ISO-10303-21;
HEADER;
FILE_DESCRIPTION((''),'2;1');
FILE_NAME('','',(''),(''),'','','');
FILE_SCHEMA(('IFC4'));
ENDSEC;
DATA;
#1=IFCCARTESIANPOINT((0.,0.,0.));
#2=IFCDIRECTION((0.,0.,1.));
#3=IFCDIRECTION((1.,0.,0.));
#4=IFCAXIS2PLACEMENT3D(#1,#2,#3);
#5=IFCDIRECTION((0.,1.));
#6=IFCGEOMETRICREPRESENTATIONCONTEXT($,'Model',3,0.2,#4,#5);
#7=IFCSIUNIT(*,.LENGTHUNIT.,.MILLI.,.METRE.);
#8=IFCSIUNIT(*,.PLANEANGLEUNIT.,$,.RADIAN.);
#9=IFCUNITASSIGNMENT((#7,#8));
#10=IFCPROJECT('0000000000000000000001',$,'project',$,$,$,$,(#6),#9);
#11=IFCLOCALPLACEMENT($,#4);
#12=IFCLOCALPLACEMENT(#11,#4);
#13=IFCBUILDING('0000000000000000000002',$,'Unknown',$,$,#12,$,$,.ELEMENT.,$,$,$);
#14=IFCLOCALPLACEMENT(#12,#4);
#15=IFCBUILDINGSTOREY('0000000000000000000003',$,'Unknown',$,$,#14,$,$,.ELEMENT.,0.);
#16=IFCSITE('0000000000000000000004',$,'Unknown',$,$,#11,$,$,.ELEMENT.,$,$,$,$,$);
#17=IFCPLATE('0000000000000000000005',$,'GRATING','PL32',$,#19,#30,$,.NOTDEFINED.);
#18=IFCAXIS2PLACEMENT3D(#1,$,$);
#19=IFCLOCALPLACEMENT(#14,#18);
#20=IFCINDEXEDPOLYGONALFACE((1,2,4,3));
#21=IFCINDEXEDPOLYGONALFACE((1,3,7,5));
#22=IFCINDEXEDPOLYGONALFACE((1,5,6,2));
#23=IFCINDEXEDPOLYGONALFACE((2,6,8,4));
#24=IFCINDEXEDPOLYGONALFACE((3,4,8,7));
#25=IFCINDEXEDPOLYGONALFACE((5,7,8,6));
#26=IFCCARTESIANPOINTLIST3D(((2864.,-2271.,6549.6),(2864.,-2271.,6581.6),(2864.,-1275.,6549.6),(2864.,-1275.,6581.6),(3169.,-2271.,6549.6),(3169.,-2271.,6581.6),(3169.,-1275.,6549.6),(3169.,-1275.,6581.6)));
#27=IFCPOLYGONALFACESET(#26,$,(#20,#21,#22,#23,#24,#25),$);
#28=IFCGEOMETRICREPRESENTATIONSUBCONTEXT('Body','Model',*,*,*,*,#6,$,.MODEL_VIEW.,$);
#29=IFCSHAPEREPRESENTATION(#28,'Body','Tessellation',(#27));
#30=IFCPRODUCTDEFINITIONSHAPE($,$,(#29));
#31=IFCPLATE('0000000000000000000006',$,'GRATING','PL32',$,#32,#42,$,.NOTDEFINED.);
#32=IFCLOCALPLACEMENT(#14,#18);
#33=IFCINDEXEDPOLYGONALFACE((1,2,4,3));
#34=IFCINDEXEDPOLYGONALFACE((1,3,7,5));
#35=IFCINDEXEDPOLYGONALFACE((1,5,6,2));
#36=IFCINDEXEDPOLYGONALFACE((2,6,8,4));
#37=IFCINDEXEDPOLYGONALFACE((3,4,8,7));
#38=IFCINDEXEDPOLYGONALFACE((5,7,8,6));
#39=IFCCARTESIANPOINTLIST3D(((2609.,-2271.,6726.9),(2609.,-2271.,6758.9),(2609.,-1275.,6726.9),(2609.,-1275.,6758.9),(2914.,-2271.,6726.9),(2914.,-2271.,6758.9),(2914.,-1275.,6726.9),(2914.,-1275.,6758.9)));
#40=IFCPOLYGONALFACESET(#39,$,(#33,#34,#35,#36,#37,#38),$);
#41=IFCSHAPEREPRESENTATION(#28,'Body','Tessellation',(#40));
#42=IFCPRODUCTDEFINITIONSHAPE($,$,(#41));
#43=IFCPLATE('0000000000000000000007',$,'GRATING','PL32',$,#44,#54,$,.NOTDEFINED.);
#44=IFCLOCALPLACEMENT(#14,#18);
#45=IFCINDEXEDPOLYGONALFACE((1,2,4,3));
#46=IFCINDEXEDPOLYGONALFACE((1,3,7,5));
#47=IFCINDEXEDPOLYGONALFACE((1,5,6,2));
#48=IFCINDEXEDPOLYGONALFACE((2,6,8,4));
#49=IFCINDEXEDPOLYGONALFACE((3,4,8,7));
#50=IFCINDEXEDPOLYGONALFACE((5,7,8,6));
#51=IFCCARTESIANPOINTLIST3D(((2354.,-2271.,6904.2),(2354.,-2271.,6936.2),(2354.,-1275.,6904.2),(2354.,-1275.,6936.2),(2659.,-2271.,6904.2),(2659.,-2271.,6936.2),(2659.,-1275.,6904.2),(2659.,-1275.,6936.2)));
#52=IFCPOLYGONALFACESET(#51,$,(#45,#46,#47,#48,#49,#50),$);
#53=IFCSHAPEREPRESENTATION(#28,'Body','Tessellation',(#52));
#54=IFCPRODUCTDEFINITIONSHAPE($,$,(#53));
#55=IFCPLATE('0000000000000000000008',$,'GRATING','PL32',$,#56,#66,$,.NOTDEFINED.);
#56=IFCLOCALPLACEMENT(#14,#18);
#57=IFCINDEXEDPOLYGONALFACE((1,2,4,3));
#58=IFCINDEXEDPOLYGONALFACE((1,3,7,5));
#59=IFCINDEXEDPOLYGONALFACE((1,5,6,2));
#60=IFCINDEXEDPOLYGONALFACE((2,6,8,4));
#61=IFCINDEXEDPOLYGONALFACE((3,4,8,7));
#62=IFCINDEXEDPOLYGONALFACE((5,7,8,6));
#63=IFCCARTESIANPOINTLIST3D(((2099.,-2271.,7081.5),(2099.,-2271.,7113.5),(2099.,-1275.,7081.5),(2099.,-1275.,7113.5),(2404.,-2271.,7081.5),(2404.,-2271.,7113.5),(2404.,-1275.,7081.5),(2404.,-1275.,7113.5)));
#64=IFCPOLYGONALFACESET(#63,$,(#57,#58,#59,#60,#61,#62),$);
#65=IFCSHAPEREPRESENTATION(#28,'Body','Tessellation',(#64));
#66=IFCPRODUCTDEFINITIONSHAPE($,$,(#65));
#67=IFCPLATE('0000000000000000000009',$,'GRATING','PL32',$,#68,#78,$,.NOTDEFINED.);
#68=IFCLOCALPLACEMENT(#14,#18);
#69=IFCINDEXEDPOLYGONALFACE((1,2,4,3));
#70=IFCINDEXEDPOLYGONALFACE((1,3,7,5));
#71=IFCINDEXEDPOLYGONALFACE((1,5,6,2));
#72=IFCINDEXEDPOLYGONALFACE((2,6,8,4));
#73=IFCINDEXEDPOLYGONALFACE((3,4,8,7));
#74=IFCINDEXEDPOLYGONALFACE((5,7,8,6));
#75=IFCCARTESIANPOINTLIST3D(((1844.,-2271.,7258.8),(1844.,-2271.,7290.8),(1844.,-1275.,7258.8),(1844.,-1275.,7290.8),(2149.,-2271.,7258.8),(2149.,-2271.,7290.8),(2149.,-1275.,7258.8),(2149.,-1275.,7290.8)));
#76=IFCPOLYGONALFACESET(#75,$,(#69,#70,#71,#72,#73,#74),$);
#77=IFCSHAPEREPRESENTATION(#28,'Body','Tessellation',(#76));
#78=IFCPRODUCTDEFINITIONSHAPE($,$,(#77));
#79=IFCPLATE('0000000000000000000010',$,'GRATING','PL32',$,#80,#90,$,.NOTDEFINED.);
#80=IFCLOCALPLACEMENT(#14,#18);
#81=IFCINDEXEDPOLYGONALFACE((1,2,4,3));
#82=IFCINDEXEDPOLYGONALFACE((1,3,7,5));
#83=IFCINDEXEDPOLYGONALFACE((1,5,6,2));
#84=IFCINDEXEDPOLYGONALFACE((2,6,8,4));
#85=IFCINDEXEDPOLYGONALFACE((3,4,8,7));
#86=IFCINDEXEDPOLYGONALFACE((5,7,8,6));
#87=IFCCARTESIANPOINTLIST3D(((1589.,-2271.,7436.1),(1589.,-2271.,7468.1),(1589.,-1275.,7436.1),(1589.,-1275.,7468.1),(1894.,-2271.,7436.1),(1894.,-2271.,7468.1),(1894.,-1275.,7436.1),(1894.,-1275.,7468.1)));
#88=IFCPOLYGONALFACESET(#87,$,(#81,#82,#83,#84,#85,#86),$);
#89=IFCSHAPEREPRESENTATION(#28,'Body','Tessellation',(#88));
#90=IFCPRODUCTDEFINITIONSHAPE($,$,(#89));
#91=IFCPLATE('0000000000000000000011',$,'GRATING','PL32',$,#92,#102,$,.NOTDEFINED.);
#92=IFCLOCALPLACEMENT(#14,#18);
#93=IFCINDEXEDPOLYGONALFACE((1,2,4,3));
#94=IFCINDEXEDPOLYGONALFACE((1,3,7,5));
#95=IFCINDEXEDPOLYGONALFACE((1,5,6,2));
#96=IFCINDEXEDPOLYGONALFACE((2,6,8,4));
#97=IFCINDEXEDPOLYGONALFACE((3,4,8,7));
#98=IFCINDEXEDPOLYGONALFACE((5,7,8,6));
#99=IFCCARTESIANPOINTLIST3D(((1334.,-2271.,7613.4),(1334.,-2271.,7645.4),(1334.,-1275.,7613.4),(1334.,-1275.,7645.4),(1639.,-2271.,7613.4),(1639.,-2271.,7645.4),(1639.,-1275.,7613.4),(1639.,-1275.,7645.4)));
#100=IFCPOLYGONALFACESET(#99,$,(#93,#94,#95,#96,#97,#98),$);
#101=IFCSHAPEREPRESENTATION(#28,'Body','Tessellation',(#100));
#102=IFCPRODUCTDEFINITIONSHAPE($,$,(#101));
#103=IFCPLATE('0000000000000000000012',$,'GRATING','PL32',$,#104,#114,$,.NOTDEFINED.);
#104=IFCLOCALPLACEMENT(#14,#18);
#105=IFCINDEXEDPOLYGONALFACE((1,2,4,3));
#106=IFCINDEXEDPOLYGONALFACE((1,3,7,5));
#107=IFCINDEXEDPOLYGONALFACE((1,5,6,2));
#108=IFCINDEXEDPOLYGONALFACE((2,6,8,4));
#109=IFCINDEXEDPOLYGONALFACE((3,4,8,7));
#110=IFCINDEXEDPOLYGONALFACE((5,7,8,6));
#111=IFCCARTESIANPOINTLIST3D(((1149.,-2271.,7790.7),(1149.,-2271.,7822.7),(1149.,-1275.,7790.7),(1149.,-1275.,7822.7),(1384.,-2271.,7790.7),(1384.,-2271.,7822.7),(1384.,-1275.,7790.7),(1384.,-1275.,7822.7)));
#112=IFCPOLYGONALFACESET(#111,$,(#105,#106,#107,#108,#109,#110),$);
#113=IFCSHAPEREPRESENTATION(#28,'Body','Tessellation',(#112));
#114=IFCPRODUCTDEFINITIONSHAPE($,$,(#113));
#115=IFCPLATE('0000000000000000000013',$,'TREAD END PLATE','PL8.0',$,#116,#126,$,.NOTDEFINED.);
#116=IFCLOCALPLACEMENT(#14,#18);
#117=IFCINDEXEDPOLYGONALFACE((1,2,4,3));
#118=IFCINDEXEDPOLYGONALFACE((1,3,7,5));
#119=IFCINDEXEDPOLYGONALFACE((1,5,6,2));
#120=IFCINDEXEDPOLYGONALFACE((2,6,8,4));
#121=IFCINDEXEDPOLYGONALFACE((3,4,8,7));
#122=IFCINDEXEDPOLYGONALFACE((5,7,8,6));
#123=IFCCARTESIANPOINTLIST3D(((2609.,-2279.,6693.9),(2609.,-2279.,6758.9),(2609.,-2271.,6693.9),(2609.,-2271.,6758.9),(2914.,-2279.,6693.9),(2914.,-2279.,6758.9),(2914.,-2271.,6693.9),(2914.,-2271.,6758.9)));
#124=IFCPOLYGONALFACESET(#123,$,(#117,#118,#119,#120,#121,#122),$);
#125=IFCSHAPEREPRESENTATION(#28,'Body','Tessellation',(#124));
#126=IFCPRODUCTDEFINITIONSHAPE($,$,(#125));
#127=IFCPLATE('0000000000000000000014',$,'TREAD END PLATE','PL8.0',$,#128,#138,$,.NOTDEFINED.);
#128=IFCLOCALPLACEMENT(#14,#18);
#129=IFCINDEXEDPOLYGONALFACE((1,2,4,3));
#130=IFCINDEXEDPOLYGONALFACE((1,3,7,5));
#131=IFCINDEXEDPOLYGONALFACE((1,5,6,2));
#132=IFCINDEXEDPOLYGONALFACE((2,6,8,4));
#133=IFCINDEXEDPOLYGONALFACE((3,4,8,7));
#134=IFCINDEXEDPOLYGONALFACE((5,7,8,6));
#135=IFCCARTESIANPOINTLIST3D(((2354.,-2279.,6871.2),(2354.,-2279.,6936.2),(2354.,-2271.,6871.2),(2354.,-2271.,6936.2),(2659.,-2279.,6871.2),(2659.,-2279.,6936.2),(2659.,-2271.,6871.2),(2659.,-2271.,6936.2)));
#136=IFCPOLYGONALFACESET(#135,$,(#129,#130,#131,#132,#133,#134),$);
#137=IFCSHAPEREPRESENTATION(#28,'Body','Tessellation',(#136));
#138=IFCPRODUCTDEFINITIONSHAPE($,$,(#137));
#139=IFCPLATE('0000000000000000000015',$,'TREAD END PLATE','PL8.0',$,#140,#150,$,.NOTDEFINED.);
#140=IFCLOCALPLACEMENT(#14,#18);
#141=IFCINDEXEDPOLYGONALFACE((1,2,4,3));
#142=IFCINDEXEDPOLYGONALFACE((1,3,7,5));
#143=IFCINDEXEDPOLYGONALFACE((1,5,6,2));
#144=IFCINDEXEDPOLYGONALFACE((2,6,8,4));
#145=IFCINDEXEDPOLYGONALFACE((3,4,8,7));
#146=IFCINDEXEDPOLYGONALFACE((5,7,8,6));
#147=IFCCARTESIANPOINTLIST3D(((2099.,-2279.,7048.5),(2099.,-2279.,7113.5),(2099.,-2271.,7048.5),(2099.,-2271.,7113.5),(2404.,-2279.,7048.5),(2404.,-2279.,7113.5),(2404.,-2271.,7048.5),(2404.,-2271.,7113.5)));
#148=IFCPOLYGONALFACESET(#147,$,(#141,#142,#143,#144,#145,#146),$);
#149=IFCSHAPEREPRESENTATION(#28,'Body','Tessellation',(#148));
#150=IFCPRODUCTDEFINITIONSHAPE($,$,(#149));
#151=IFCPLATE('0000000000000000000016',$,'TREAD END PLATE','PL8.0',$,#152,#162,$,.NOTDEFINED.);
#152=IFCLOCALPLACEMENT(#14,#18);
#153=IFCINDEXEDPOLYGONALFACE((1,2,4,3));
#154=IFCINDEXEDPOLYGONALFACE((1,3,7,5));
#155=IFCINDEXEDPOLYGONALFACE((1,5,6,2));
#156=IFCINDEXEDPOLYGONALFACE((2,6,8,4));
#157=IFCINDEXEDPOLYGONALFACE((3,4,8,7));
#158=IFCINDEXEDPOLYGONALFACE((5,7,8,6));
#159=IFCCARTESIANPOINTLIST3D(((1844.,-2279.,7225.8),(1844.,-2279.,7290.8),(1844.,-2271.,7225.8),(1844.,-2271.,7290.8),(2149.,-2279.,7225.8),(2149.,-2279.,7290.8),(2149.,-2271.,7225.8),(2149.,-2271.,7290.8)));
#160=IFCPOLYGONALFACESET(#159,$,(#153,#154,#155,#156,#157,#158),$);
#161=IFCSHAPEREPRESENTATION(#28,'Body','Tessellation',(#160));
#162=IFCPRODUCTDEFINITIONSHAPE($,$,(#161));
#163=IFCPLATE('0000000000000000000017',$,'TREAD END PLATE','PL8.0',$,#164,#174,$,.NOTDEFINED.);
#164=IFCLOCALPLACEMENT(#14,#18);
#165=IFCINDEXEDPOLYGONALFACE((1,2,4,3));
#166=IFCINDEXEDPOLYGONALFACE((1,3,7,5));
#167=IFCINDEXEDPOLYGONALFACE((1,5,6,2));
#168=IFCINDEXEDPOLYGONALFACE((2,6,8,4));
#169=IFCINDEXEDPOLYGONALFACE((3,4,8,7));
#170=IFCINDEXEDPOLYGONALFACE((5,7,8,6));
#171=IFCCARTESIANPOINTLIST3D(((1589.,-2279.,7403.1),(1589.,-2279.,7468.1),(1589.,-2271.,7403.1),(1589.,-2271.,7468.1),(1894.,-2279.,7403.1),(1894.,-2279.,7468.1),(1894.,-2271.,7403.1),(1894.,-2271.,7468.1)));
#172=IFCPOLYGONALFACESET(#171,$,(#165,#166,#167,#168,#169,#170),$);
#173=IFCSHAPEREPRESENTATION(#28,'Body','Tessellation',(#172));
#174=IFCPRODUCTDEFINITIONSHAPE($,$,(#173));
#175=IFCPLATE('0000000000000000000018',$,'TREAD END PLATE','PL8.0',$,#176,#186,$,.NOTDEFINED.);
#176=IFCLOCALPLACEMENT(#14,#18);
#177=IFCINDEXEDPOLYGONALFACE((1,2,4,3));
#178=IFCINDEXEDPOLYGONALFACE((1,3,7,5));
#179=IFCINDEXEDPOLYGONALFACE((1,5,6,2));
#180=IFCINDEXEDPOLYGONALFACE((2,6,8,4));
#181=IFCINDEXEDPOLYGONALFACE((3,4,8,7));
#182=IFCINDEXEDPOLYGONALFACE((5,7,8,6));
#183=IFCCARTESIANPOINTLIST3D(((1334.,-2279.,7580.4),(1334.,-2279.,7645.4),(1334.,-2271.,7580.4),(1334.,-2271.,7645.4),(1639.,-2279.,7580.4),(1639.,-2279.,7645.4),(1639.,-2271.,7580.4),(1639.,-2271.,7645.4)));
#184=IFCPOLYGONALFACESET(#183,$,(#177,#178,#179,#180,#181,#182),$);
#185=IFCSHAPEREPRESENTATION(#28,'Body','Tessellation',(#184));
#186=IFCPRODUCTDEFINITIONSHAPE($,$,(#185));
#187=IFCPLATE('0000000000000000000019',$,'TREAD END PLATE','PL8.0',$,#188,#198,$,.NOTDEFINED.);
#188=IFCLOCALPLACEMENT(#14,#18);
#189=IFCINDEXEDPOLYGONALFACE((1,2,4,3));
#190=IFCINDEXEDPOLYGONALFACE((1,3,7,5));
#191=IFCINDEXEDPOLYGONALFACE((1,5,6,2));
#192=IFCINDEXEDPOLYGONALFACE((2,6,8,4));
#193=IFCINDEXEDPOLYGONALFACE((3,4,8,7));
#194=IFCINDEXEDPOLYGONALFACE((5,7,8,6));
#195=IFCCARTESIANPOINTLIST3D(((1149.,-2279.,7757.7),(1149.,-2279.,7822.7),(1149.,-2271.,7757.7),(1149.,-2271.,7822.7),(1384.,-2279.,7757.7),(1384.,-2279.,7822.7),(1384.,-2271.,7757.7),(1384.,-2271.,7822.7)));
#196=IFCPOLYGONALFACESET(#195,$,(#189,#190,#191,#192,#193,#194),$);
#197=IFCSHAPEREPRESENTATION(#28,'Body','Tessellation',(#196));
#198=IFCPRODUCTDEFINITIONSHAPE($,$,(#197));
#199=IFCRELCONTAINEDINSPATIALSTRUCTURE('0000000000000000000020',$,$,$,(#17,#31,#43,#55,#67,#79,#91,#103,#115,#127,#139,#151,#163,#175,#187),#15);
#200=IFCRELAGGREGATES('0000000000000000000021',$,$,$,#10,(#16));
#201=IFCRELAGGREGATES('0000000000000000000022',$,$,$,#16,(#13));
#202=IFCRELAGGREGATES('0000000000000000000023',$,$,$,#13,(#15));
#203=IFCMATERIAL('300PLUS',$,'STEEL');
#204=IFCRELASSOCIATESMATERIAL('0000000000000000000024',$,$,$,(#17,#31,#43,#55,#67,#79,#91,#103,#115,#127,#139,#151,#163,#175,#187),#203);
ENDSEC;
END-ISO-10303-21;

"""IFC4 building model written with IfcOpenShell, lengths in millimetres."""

from ifc_helpers import new_model, si_unit, direction, frame, origin_with_axes, place, context, subcontext, project, spatial, line, indexed_curve, outline, extrude, material, element, save


model = new_model("IFC4")

# Units and contexts
model_context = context("Model", 3, precision=0.2, world=origin_with_axes(), true_north=direction((0.0, 1.0)))
body_context = subcontext(model_context, "Body", "Model", "MODEL_VIEW")
ifc_project = project(units=[si_unit("LENGTHUNIT", "METRE", prefix="MILLI"), si_unit("PLANEANGLEUNIT", "RADIAN")], contexts=[model_context])

# Site, building, storey
site_placement = place(None, origin_with_axes())
site = spatial("IfcSite", under=ifc_project, at=site_placement, Name="Unknown", CompositionType="ELEMENT")
building_placement = place(site_placement, origin_with_axes())
building = spatial("IfcBuilding", under=site, at=building_placement, Name="Unknown", CompositionType="ELEMENT")
storey_placement = place(building_placement, origin_with_axes())
storey = spatial("IfcBuildingStorey", under=building, at=storey_placement, Name="Unknown", CompositionType="ELEMENT", Elevation=0.0)

# Shared definitions
ifc_material_1 = material(Name="300PLUS", Category="STEEL")

# Plates
for number, where, z_axis, x_axis, name in (
    (1, (2864.0, -2271.0, 6565.6), (0.0, 0.0, 1.0), (1.0, 0.0, 0.0), "GRATING"),
    (2, (2609.0, -2271.0, 6742.9), (0.0, 0.0, 1.0), (1.0, 0.0, 0.0), "GRATING"),
    (3, (2354.0, -2271.0, 6920.2), (0.0, 0.0, 1.0), (1.0, 0.0, 0.0), "GRATING"),
    (4, (2099.0, -2271.0, 7097.5), (0.0, 0.0, 1.0), (1.0, 0.0, 0.0), "GRATING"),
    (5, (1844.0, -2271.0, 7274.8), (0.0, 0.0, 1.0), (1.0, 0.0, 0.0), "GRATING"),
    (6, (1589.0, -2271.0, 7452.1), (0.0, 0.0, 1.0), (1.0, 0.0, 0.0), "GRATING"),
    (7, (1334.0, -2271.0, 7629.4), (0.0, 0.0, 1.0), (1.0, 0.0, 0.0), "GRATING"),
):
    element("IfcPlate", number, at=place(storey_placement, frame(where, z_axis=z_axis, x_axis=x_axis)), inside=storey, material=ifc_material_1, Name=name, Description="PL32", PredefinedType="NOTDEFINED", context=body_context, shape_type="SolidModel", body=[
        extrude(outline(indexed_curve([(0.0, 0.0), (305.0, 0.0), (305.0, 996.0), (0.0, 996.0)], segments=[line(1, 2, 3, 4, 1)])), frame((0.0, 0.0, 16.0), z_axis=(0.0, 0.0, 1.0), x_axis=(1.0, 0.0, 0.0)), (0.0, 0.0, -1.0), 32.0),
    ])
plate_1_placement = place(storey_placement, frame((1149.0, -2271.0, 7806.7), z_axis=(0.0, 0.0, 1.0), x_axis=(1.0, 0.0, 0.0)))
element("IfcPlate", 8, at=plate_1_placement, inside=storey, material=ifc_material_1, Name="GRATING", Description="PL32", PredefinedType="NOTDEFINED", context=body_context, shape_type="SolidModel", body=[
    extrude(outline(indexed_curve([(0.0, 0.0), (235.0, 0.0), (235.0, 996.0), (0.0, 996.0)], segments=[line(1, 2, 3, 4, 1)])), frame((0.0, 0.0, 16.0), z_axis=(0.0, 0.0, 1.0), x_axis=(1.0, 0.0, 0.0)), (0.0, 0.0, -1.0), 32.0),
])
for number, where, z_axis, x_axis, name in (
    (9, (2609.0, -2275.0, 6758.9), (0.0, 1.0, 0.0), (1.0, 0.0, 0.0), "TREAD END PLATE"),
    (10, (2354.0, -2275.0, 6936.2), (0.0, 1.0, 0.0), (1.0, 0.0, 0.0), "TREAD END PLATE"),
    (11, (2099.0, -2275.0, 7113.5), (0.0, 1.0, 0.0), (1.0, 0.0, 0.0), "TREAD END PLATE"),
    (12, (1844.0, -2275.0, 7290.8), (0.0, 1.0, 0.0), (1.0, 0.0, 0.0), "TREAD END PLATE"),
    (13, (1589.0, -2275.0, 7468.1), (0.0, 1.0, 0.0), (1.0, 0.0, 0.0), "TREAD END PLATE"),
    (14, (1334.0, -2275.0, 7645.4), (0.0, 1.0, 0.0), (1.0, 0.0, 0.0), "TREAD END PLATE"),
):
    element("IfcPlate", number, at=place(storey_placement, frame(where, z_axis=z_axis, x_axis=x_axis)), inside=storey, material=ifc_material_1, Name=name, Description="PL8.0", PredefinedType="NOTDEFINED", context=body_context, shape_type="SolidModel", body=[
        extrude(outline(indexed_curve([(0.0, 0.0), (305.0, 0.0), (305.0, 65.0), (0.0, 65.0)], segments=[line(1, 2, 3, 4, 1)])), frame((0.0, 0.0, 4.0), z_axis=(0.0, 0.0, 1.0), x_axis=(1.0, 0.0, 0.0)), (0.0, 0.0, -1.0), 8.0),
    ])
plate_2_placement = place(storey_placement, frame((1149.0, -2275.0, 7822.7), z_axis=(0.0, 1.0, 0.0), x_axis=(1.0, 0.0, 0.0)))
element("IfcPlate", 15, at=plate_2_placement, inside=storey, material=ifc_material_1, Name="TREAD END PLATE", Description="PL8.0", PredefinedType="NOTDEFINED", context=body_context, shape_type="SolidModel", body=[
    extrude(outline(indexed_curve([(0.0, 0.0), (235.0, 0.0), (235.0, 65.0), (0.0, 65.0)], segments=[line(1, 2, 3, 4, 1)])), frame((0.0, 0.0, 4.0), z_axis=(0.0, 0.0, 1.0), x_axis=(1.0, 0.0, 0.0)), (0.0, 0.0, -1.0), 8.0),
])

save(model, "model.ifc")
